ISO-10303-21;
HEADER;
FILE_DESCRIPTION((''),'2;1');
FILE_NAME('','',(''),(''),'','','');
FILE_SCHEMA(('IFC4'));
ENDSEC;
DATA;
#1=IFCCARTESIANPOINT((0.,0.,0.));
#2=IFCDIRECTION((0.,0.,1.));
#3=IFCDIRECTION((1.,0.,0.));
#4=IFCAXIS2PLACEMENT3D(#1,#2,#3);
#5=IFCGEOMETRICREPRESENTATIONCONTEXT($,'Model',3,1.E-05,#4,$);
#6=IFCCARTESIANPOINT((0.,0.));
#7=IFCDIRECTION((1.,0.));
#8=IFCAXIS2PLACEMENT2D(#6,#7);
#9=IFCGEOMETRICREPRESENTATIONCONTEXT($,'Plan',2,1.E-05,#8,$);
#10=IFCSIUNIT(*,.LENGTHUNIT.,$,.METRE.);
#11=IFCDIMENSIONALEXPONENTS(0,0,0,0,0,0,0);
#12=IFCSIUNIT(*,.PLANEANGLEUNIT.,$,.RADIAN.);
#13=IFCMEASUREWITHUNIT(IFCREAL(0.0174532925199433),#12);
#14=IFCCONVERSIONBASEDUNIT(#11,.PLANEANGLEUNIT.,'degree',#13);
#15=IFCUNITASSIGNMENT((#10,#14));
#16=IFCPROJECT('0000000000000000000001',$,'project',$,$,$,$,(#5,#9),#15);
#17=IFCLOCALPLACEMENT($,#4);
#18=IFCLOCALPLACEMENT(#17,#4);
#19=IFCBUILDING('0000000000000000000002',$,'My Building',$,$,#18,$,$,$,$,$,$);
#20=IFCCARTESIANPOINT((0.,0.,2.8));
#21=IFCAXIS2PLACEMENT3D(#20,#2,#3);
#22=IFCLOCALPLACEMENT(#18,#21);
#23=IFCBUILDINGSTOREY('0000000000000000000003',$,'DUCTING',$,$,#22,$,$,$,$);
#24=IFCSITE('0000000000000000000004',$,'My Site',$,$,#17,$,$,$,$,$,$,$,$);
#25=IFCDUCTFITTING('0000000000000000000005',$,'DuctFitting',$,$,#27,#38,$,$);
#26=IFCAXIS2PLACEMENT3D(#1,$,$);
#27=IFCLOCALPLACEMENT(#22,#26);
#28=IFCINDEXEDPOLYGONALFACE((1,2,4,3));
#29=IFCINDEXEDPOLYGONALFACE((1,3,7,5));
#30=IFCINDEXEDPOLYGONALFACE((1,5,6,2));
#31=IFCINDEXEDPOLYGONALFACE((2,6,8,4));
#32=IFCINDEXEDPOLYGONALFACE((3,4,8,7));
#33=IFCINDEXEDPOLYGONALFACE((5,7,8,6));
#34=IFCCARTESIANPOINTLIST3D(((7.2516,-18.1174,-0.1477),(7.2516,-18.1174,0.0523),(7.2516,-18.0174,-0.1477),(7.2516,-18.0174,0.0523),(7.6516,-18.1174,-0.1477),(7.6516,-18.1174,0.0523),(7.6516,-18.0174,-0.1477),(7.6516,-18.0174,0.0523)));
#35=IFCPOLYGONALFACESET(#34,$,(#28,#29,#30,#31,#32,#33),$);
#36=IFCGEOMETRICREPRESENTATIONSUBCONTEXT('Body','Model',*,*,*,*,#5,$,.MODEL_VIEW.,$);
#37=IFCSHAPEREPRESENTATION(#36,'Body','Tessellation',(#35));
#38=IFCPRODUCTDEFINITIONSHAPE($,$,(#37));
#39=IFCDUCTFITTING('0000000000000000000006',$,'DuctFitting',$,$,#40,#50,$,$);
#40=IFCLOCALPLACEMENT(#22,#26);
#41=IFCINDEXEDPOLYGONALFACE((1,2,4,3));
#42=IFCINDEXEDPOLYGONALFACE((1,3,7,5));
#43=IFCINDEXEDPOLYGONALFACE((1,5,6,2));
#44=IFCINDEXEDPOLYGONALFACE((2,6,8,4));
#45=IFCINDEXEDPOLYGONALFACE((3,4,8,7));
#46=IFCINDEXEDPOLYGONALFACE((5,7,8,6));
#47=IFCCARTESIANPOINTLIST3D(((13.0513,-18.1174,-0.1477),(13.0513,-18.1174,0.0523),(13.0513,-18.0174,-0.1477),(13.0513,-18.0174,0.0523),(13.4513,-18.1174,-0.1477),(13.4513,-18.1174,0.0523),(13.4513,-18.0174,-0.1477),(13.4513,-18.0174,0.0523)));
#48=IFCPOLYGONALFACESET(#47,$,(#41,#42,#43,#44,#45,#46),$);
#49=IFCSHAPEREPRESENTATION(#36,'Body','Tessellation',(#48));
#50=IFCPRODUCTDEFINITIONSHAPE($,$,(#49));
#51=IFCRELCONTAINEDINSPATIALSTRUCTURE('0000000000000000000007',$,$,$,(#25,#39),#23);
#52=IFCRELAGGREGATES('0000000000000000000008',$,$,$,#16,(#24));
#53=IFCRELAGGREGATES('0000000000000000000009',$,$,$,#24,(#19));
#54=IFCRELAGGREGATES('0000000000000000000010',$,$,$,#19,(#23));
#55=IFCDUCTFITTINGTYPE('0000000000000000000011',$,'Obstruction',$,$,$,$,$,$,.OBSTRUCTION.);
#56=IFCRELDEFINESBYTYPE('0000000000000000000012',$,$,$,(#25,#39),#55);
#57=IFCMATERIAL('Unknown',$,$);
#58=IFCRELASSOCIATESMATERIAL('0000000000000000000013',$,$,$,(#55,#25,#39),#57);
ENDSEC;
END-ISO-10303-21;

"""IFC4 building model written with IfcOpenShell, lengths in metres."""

from ifc_helpers import new_model, entity, si_unit, converted_unit, frame, origin_with_axes, origin_2d_with_axis, place, context, subcontext, project, spatial, rectangle, extrude, material, material_profile, profile_set, profile_usage, type_object, element, save


model = new_model("IFC4")

# Units and contexts
model_context = context("Model", 3, precision=1e-05, world=origin_with_axes())
plan_context = context("Plan", 2, precision=1e-05, world=origin_2d_with_axis())
body_context = subcontext(model_context, "Body", "Model", "MODEL_VIEW")
ifc_project = project(units=[si_unit("LENGTHUNIT", "METRE"), converted_unit("PLANEANGLEUNIT", "degree", entity("IfcReal", 0.0174532925199433), si_unit("PLANEANGLEUNIT", "RADIAN"), dimensions=[0, 0, 0, 0, 0, 0, 0])], contexts=[model_context, plan_context])

# Site, building, storey
site_placement = place(None, origin_with_axes())
site = spatial("IfcSite", under=ifc_project, at=site_placement, Name="My Site")
building_placement = place(site_placement, origin_with_axes())
building = spatial("IfcBuilding", under=site, at=building_placement, Name="My Building")
storey_placement = place(building_placement, frame((0.0, 0.0, 2.8), z_axis=(0.0, 0.0, 1.0), x_axis=(1.0, 0.0, 0.0)))
storey = spatial("IfcBuildingStorey", under=building, at=storey_placement, Name="DUCTING")

# Shared definitions
ifc_material = material(Name="Unknown")

# Duct fittings
ifc_material_profile_1 = material_profile(ifc_material, rectangle(XDim=0.4, YDim=0.2))
ifc_profile_set_1 = profile_set([ifc_material_profile_1])
duct_fitting_type_1 = type_object("IfcDuctFittingType", Name="Obstruction", PredefinedType="OBSTRUCTION", material=ifc_profile_set_1)
ifc_profile_usage_1 = profile_usage(ifc_profile_set_1, cardinal=5)
duct_fitting_1_placement = place(storey_placement, frame((7.4516, -18.1174, -0.0477), z_axis=(0.0, 1.0, 0.0), x_axis=(-1.0, 0.0, 0.0)))
element("IfcDuctFitting", 1, at=duct_fitting_1_placement, inside=storey, type_object=duct_fitting_type_1, material=ifc_profile_usage_1, Name="DuctFitting", context=body_context, shape_type="SweptSolid", body=[
    extrude(rectangle(XDim=0.4, YDim=0.2), origin_with_axes(), (0.0, 0.0, 1.0), 0.1),
])
ifc_profile_usage_2 = profile_usage(ifc_profile_set_1, cardinal=5)
duct_fitting_2_placement = place(storey_placement, frame((13.2513, -18.1174, -0.0477), z_axis=(0.0, 1.0, 0.0), x_axis=(-1.0, 0.0, 0.0)))
element("IfcDuctFitting", 2, at=duct_fitting_2_placement, inside=storey, type_object=duct_fitting_type_1, material=ifc_profile_usage_2, Name="DuctFitting", context=body_context, shape_type="SweptSolid", body=[
    extrude(rectangle(XDim=0.4, YDim=0.2), origin_with_axes(), (0.0, 0.0, 1.0), 0.1),
])

save(model, "model.ifc")
